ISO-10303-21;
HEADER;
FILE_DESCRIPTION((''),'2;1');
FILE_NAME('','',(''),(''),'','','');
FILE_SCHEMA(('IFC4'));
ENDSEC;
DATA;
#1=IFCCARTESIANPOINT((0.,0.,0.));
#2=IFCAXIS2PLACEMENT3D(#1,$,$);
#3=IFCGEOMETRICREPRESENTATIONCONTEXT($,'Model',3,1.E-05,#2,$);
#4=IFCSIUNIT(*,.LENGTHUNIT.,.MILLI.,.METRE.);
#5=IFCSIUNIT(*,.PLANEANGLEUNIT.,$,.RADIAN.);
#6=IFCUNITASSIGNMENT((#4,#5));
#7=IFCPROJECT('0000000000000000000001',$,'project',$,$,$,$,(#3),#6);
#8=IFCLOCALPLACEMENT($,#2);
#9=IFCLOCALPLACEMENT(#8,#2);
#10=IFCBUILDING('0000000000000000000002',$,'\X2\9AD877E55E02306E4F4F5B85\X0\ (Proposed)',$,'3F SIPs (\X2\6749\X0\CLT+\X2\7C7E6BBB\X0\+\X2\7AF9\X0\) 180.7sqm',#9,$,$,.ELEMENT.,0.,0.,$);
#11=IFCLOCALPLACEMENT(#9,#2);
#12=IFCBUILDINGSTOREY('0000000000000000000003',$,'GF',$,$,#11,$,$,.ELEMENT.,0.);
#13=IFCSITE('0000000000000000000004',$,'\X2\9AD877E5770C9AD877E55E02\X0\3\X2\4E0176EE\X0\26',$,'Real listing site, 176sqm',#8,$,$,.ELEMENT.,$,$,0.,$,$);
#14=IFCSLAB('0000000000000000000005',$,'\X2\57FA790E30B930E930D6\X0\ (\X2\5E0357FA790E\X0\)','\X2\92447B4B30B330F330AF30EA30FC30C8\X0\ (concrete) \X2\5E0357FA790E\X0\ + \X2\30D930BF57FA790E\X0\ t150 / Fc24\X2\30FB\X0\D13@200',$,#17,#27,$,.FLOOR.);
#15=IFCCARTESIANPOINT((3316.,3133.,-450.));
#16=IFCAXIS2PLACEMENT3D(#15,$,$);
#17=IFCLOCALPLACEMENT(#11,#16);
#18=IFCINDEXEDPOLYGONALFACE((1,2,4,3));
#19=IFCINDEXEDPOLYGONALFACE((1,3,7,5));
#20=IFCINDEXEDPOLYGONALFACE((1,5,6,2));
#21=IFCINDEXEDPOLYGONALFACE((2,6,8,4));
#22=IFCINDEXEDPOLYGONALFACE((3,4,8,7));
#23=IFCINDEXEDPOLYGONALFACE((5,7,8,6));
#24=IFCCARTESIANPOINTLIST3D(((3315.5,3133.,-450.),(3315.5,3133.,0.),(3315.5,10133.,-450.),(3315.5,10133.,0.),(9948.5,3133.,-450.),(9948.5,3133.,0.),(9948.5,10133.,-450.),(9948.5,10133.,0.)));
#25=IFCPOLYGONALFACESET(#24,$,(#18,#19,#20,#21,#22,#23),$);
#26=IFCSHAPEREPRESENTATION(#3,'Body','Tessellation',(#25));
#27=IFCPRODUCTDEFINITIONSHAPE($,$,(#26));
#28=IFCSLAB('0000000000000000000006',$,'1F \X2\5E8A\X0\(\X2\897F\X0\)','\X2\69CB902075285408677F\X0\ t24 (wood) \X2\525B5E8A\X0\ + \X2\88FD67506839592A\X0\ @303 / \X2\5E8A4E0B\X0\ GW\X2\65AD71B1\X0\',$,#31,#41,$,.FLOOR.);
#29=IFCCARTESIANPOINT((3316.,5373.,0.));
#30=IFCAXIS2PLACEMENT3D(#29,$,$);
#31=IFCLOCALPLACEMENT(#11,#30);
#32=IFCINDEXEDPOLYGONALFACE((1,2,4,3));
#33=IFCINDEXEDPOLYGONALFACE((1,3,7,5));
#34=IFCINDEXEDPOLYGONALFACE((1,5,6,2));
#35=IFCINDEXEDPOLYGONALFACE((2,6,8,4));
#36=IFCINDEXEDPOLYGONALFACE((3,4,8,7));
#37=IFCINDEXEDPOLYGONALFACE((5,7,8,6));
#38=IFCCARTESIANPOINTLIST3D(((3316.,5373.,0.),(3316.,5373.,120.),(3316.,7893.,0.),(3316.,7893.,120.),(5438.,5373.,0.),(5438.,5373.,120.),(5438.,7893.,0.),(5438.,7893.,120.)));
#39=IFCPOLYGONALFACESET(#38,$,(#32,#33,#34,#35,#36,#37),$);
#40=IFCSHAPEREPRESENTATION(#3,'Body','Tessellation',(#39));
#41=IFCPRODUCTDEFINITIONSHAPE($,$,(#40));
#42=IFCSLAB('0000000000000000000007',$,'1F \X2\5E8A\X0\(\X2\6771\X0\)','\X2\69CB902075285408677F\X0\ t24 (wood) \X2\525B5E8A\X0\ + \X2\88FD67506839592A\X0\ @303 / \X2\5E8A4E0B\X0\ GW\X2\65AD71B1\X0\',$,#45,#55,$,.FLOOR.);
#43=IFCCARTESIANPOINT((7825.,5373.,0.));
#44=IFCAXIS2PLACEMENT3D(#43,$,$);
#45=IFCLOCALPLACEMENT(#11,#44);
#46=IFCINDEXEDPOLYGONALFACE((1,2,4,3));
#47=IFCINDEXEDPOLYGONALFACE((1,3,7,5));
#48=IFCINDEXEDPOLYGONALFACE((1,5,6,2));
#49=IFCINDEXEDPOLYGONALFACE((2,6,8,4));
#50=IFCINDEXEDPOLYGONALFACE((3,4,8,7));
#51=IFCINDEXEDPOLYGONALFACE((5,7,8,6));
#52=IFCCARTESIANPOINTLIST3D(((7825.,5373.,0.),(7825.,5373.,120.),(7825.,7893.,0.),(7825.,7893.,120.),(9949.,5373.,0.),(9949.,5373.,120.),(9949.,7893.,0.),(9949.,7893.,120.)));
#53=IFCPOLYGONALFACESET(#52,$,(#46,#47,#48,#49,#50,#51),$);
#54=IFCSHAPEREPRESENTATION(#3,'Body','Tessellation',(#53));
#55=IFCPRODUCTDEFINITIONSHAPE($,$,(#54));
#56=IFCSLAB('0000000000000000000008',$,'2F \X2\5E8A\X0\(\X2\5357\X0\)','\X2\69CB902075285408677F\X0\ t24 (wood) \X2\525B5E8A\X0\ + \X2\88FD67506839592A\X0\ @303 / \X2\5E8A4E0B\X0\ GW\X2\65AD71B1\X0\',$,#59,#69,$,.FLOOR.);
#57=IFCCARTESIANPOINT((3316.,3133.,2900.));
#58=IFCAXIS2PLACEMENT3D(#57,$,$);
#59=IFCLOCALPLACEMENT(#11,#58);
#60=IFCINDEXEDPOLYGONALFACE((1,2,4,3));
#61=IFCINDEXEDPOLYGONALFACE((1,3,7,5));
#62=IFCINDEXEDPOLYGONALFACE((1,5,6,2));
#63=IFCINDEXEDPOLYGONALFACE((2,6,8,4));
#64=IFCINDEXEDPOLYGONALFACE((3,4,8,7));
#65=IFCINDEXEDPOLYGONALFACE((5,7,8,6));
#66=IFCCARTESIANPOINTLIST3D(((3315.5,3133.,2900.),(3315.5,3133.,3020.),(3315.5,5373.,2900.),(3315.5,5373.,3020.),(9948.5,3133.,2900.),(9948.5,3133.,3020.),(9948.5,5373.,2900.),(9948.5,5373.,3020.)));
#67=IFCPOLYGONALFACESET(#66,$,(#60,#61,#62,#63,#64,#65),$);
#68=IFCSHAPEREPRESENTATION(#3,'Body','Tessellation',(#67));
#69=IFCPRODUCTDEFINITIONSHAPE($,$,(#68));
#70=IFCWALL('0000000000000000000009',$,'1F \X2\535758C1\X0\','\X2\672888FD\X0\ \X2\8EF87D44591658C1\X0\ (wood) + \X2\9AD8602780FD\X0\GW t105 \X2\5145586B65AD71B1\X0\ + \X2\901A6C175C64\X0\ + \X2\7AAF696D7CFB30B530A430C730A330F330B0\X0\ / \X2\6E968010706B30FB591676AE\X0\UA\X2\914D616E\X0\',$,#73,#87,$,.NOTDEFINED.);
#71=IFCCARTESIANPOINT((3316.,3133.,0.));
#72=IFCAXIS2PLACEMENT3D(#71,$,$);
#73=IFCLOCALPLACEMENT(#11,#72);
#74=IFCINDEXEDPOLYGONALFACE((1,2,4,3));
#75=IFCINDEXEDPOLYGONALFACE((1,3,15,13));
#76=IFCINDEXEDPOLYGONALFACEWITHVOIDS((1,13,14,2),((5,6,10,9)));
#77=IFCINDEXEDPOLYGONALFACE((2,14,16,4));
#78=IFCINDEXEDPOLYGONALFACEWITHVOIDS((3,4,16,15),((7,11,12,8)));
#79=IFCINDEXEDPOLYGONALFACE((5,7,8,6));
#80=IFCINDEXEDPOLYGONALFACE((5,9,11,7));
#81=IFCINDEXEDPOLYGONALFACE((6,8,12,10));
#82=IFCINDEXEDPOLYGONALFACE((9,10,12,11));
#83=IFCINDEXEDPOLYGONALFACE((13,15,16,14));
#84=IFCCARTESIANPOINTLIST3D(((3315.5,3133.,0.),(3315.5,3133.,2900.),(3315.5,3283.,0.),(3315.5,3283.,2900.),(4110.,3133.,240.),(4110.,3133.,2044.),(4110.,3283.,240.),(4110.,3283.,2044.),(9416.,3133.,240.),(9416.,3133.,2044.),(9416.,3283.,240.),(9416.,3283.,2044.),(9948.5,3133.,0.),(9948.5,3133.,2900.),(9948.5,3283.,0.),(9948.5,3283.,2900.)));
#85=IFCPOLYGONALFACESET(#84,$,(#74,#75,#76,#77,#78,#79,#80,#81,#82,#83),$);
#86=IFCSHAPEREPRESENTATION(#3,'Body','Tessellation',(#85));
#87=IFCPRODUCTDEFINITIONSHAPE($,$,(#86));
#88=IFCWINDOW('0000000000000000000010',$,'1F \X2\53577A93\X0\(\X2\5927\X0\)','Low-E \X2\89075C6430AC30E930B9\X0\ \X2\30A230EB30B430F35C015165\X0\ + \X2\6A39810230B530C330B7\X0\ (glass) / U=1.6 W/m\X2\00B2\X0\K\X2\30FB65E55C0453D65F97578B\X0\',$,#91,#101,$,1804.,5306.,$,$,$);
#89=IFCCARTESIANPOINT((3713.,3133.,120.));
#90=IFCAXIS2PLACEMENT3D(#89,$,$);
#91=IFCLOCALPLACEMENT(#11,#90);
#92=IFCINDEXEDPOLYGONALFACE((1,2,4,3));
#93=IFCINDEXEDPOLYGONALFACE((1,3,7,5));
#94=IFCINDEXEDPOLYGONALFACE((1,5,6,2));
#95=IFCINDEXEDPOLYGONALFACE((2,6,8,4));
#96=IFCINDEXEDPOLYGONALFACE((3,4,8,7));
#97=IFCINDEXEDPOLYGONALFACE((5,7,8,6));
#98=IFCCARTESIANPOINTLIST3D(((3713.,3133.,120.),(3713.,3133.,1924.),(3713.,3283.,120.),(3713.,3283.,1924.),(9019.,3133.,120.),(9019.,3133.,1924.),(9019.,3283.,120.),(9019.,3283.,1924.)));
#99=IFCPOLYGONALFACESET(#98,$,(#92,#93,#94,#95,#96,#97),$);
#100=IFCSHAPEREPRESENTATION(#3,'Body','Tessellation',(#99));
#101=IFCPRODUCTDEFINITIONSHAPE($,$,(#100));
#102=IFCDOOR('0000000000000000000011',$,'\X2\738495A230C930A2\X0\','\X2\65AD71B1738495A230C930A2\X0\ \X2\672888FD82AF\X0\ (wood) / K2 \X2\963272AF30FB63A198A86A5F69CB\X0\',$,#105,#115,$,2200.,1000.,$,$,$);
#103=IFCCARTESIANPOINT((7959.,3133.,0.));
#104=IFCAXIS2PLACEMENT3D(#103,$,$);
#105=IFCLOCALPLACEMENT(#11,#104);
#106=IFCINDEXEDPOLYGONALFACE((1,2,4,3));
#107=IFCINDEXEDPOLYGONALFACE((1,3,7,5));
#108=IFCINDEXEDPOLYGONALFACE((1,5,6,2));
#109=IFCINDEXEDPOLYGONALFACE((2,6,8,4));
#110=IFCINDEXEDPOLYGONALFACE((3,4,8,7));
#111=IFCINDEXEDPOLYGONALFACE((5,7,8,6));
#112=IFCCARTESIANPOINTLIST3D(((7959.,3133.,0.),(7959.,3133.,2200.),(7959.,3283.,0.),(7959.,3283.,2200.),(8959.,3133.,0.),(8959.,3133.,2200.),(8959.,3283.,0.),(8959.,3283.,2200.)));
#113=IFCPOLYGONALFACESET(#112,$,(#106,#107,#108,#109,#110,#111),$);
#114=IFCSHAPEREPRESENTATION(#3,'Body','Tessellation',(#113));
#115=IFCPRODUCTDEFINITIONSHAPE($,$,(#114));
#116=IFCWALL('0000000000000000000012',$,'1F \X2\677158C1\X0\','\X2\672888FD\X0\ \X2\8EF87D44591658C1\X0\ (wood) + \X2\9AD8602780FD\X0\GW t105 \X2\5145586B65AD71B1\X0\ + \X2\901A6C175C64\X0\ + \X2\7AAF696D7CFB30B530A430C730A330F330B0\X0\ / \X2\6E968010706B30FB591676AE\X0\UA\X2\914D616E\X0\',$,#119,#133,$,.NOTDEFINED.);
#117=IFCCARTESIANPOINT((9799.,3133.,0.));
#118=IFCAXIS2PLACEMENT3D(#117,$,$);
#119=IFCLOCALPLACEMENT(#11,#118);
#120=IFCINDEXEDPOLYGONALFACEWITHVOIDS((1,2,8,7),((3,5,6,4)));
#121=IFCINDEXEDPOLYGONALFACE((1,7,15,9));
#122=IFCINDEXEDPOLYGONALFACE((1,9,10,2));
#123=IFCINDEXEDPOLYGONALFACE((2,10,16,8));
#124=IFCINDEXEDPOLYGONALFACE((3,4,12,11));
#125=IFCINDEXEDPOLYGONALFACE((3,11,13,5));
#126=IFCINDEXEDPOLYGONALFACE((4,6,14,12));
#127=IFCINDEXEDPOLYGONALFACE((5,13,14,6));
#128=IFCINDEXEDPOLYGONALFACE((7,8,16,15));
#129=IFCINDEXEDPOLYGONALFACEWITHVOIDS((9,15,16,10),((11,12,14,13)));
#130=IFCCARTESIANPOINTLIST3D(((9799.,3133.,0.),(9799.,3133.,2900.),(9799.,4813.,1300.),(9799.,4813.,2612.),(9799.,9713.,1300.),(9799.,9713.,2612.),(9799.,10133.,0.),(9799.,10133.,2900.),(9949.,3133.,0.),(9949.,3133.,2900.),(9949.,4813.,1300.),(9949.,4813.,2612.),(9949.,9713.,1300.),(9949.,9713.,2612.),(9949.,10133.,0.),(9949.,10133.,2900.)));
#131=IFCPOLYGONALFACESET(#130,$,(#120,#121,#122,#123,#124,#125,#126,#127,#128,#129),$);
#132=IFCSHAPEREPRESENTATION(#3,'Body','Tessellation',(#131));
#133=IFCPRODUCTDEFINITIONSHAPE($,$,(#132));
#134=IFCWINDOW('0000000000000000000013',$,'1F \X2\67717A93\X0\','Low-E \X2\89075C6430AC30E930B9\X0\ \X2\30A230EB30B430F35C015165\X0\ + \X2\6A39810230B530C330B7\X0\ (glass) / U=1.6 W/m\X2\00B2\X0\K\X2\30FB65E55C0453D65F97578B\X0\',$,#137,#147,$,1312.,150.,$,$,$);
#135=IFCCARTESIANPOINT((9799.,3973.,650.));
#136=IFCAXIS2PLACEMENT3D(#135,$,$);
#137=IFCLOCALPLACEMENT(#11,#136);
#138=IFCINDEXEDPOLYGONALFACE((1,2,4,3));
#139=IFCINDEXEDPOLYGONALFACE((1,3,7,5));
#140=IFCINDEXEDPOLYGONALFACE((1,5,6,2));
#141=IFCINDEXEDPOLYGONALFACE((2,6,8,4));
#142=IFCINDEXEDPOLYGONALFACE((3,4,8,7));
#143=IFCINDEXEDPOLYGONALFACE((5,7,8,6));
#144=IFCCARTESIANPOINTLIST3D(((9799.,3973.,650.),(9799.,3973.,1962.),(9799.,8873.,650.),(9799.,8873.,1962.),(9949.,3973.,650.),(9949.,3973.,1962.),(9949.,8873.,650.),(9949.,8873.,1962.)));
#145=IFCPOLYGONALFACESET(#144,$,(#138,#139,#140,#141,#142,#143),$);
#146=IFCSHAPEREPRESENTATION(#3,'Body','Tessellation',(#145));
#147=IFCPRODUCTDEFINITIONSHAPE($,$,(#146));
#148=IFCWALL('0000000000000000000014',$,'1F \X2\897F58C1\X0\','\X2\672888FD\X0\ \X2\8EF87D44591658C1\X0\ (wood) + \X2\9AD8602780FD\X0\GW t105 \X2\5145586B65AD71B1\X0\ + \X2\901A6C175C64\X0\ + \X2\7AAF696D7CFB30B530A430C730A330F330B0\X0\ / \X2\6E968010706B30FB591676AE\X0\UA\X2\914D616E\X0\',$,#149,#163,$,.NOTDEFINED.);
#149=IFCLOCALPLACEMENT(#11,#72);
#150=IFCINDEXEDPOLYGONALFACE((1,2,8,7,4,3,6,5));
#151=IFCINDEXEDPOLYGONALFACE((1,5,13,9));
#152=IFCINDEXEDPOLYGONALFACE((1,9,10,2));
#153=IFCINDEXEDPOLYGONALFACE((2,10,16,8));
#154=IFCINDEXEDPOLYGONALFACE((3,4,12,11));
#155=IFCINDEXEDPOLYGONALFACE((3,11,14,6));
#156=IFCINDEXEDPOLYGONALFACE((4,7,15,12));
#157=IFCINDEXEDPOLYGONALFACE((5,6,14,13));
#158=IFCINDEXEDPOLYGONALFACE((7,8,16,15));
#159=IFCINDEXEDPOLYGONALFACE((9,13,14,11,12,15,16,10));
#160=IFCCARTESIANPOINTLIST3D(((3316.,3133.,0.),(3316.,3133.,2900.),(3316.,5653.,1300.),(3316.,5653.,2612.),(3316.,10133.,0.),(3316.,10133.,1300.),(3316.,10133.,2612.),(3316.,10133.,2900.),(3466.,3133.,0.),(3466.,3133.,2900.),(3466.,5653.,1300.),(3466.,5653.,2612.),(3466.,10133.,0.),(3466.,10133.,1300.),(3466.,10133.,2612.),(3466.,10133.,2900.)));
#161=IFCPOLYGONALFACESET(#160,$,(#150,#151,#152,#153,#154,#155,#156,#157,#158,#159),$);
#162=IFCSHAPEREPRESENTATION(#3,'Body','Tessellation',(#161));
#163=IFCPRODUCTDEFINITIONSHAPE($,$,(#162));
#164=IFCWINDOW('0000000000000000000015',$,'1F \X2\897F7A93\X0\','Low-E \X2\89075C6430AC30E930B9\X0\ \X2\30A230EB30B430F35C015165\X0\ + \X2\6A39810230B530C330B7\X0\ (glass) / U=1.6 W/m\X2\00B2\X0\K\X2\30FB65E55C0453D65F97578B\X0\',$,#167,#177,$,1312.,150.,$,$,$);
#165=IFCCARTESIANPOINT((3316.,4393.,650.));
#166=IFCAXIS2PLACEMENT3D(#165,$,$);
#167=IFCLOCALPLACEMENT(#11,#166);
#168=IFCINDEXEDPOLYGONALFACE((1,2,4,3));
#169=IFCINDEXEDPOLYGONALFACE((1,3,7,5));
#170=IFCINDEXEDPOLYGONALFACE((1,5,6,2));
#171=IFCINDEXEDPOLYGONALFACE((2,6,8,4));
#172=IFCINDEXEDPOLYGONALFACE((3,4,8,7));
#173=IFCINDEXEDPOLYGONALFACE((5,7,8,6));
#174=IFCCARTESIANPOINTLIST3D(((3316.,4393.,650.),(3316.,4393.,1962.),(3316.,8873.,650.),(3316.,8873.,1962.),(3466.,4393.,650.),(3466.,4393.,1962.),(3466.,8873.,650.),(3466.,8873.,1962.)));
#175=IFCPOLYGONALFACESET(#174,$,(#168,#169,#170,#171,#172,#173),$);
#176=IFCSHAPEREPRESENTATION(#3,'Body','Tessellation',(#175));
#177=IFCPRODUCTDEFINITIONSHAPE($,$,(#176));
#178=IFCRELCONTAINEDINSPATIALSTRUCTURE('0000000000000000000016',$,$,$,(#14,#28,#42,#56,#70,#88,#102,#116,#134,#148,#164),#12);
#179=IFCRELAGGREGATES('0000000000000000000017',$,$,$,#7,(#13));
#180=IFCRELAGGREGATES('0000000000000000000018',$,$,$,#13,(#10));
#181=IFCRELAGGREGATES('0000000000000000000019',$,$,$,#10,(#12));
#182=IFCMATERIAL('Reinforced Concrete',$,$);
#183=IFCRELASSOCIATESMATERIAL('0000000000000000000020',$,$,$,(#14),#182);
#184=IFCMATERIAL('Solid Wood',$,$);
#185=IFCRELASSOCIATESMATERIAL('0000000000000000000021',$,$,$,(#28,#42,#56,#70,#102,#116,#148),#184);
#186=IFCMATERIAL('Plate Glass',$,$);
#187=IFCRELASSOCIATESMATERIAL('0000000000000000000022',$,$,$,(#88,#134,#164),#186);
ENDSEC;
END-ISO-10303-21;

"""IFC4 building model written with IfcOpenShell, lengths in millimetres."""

from ifc_helpers import new_model, si_unit, frame, frame_2d, origin, place, context, project, spatial, rectangle, extrude, material, element, fill, save


model = new_model("IFC4")

# Units and contexts
model_context = context("Model", 3, precision=1e-05, world=origin())
ifc_project = project(units=[si_unit("LENGTHUNIT", "METRE", prefix="MILLI"), si_unit("PLANEANGLEUNIT", "RADIAN")], contexts=[model_context])

# Site, building, storey
site_placement = place(None, origin())
site = spatial("IfcSite", under=ifc_project, at=site_placement, Name="高知県高知市3丁目26", ObjectType="Real listing site, 176sqm", CompositionType="ELEMENT", RefElevation=0.0)
building_placement = place(site_placement, origin())
building = spatial("IfcBuilding", under=site, at=building_placement, Name="高知市の住宅 (Proposed)", ObjectType="3F SIPs (杉CLT+籾殻+竹) 180.7sqm", CompositionType="ELEMENT", ElevationOfRefHeight=0.0, ElevationOfTerrain=0.0)
storey_placement = place(building_placement, origin())
storey = spatial("IfcBuildingStorey", under=building, at=storey_placement, Name="GF", CompositionType="ELEMENT", Elevation=0.0)

# Slabs
ifc_material_1 = material(Name="Reinforced Concrete")
slab_1_placement = place(storey_placement, frame((3316.0, 3133.0, -450.0)))
element("IfcSlab", 1, at=slab_1_placement, inside=storey, material=ifc_material_1, Name="基礎スラブ (布基礎)", Description="鉄筋コンクリート (concrete) 布基礎 + ベタ基礎 t150 / Fc24・D13@200", PredefinedType="FLOOR", context=model_context, shape_type="SweptSolid", body=[
    extrude(rectangle(XDim=6633.0, YDim=7000.0, at=frame_2d((3316.0, 3500.0))), frame((3316.0, 3133.0, -450.0)), (0.0, 0.0, 1.0), 450.0),
])
ifc_material_2 = material(Name="Solid Wood")
slab_2_placement = place(storey_placement, frame((3316.0, 5373.0, 0.0)))
element("IfcSlab", 2, at=slab_2_placement, inside=storey, material=ifc_material_2, Name="1F 床(西)", Description="構造用合板 t24 (wood) 剛床 + 製材根太 @303 / 床下 GW断熱", PredefinedType="FLOOR", context=model_context, shape_type="SweptSolid", body=[
    extrude(rectangle(XDim=2122.0, YDim=2520.0, at=frame_2d((1061.0, 1260.0))), frame((3316.0, 5373.0, 0.0)), (0.0, 0.0, 1.0), 120.0),
])
slab_3_placement = place(storey_placement, frame((7825.0, 5373.0, 0.0)))
element("IfcSlab", 3, at=slab_3_placement, inside=storey, material=ifc_material_2, Name="1F 床(東)", Description="構造用合板 t24 (wood) 剛床 + 製材根太 @303 / 床下 GW断熱", PredefinedType="FLOOR", context=model_context, shape_type="SweptSolid", body=[
    extrude(rectangle(XDim=2124.0, YDim=2520.0, at=frame_2d((1062.0, 1260.0))), frame((7825.0, 5373.0, 0.0)), (0.0, 0.0, 1.0), 120.0),
])
slab_4_placement = place(storey_placement, frame((3316.0, 3133.0, 2900.0)))
element("IfcSlab", 4, at=slab_4_placement, inside=storey, material=ifc_material_2, Name="2F 床(南)", Description="構造用合板 t24 (wood) 剛床 + 製材根太 @303 / 床下 GW断熱", PredefinedType="FLOOR", context=model_context, shape_type="SweptSolid", body=[
    extrude(rectangle(XDim=6633.0, YDim=2240.0, at=frame_2d((3316.0, 1120.0))), frame((3316.0, 3133.0, 2900.0)), (0.0, 0.0, 1.0), 120.0),
])

# Wall, openings, window, door
wall_1_placement = place(storey_placement, frame((3316.0, 3133.0, 0.0)))
wall_1 = element("IfcWall", 5, at=wall_1_placement, inside=storey, material=ifc_material_2, Name="1F 南壁", Description="木製 軸組外壁 (wood) + 高性能GW t105 充填断熱 + 通気層 + 窯業系サイディング / 準耐火・外皮UA配慮", PredefinedType="NOTDEFINED", context=model_context, shape_type="SweptSolid", body=[
    extrude(rectangle(XDim=6633.0, YDim=150.0, at=frame_2d((3316.0, 75.0))), frame((3316.0, 3133.0, 0.0)), (0.0, 0.0, 1.0), 2900.0),
])
opening_1_placement = place(storey_placement, frame((3713.0, 3133.0, 120.0)))
opening_1 = element("IfcOpeningElement", 6, at=opening_1_placement, cuts=wall_1, PredefinedType="NOTDEFINED", context=model_context, shape_type="SweptSolid", body=[
    extrude(rectangle(XDim=5306.0, YDim=150.0, at=frame_2d((2653.0, 75.0))), frame((3713.0, 3133.0, 120.0)), (0.0, 0.0, 1.0), 1804.0),
])
opening_2_placement = place(storey_placement, frame((7959.0, 3133.0, 0.0)))
opening_2 = element("IfcOpeningElement", 7, at=opening_2_placement, cuts=wall_1, PredefinedType="NOTDEFINED", context=model_context, shape_type="SweptSolid", body=[
    extrude(rectangle(XDim=1000.0, YDim=150.0, at=frame_2d((500.0, 75.0))), frame((7959.0, 3133.0, 0.0)), (0.0, 0.0, 1.0), 2200.0),
])
ifc_material_3 = material(Name="Plate Glass")
window_1_placement = place(storey_placement, frame((3713.0, 3133.0, 120.0)))
window_1 = element("IfcWindow", 8, at=window_1_placement, inside=storey, material=ifc_material_3, Name="1F 南窓(大)", Description="Low-E 複層ガラス アルゴン封入 + 樹脂サッシ (glass) / U=1.6 W/m²K・日射取得型", OverallHeight=1804.0, OverallWidth=5306.0, context=model_context, shape_type="SweptSolid", body=[
    extrude(rectangle(XDim=5306.0, YDim=150.0, at=frame_2d((2653.0, 75.0))), frame((3713.0, 3133.0, 120.0)), (0.0, 0.0, 1.0), 1804.0),
])
fill(opening_1, window_1)
door_placement = place(storey_placement, frame((7959.0, 3133.0, 0.0)))
door = element("IfcDoor", 9, at=door_placement, inside=storey, material=ifc_material_2, Name="玄関ドア", Description="断熱玄関ドア 木製芯 (wood) / K2 防犯・採風機構", OverallHeight=2200.0, OverallWidth=1000.0, context=model_context, shape_type="SweptSolid", body=[
    extrude(rectangle(XDim=1000.0, YDim=150.0, at=frame_2d((500.0, 75.0))), frame((7959.0, 3133.0, 0.0)), (0.0, 0.0, 1.0), 2200.0),
])
fill(opening_2, door)

# Walls, openings, windows
wall_2_placement = place(storey_placement, frame((9799.0, 3133.0, 0.0)))
wall_2 = element("IfcWall", 10, at=wall_2_placement, inside=storey, material=ifc_material_2, Name="1F 東壁", Description="木製 軸組外壁 (wood) + 高性能GW t105 充填断熱 + 通気層 + 窯業系サイディング / 準耐火・外皮UA配慮", PredefinedType="NOTDEFINED", context=model_context, shape_type="SweptSolid", body=[
    extrude(rectangle(XDim=150.0, YDim=7000.0, at=frame_2d((75.0, 3500.0))), frame((9799.0, 3133.0, 0.0)), (0.0, 0.0, 1.0), 2900.0),
])
opening_3_placement = place(storey_placement, frame((9799.0, 3973.0, 650.0)))
opening_3 = element("IfcOpeningElement", 11, at=opening_3_placement, cuts=wall_2, PredefinedType="NOTDEFINED", context=model_context, shape_type="SweptSolid", body=[
    extrude(rectangle(XDim=150.0, YDim=4900.0, at=frame_2d((75.0, 2450.0))), frame((9799.0, 3973.0, 650.0)), (0.0, 0.0, 1.0), 1312.0),
])
window_2_placement = place(storey_placement, frame((9799.0, 3973.0, 650.0)))
window_2 = element("IfcWindow", 12, at=window_2_placement, inside=storey, material=ifc_material_3, Name="1F 東窓", Description="Low-E 複層ガラス アルゴン封入 + 樹脂サッシ (glass) / U=1.6 W/m²K・日射取得型", OverallHeight=1312.0, OverallWidth=150.0, context=model_context, shape_type="SweptSolid", body=[
    extrude(rectangle(XDim=150.0, YDim=4900.0, at=frame_2d((75.0, 2450.0))), frame((9799.0, 3973.0, 650.0)), (0.0, 0.0, 1.0), 1312.0),
])
fill(opening_3, window_2)
wall_3_placement = place(storey_placement, frame((3316.0, 3133.0, 0.0)))
wall_3 = element("IfcWall", 13, at=wall_3_placement, inside=storey, material=ifc_material_2, Name="1F 西壁", Description="木製 軸組外壁 (wood) + 高性能GW t105 充填断熱 + 通気層 + 窯業系サイディング / 準耐火・外皮UA配慮", PredefinedType="NOTDEFINED", context=model_context, shape_type="SweptSolid", body=[
    extrude(rectangle(XDim=150.0, YDim=7000.0, at=frame_2d((75.0, 3500.0))), frame((3316.0, 3133.0, 0.0)), (0.0, 0.0, 1.0), 2900.0),
])
opening_4_placement = place(storey_placement, frame((3316.0, 4393.0, 650.0)))
opening_4 = element("IfcOpeningElement", 14, at=opening_4_placement, cuts=wall_3, PredefinedType="NOTDEFINED", context=model_context, shape_type="SweptSolid", body=[
    extrude(rectangle(XDim=150.0, YDim=4480.0, at=frame_2d((75.0, 2240.0))), frame((3316.0, 4393.0, 650.0)), (0.0, 0.0, 1.0), 1312.0),
])
window_3_placement = place(storey_placement, frame((3316.0, 4393.0, 650.0)))
window_3 = element("IfcWindow", 15, at=window_3_placement, inside=storey, material=ifc_material_3, Name="1F 西窓", Description="Low-E 複層ガラス アルゴン封入 + 樹脂サッシ (glass) / U=1.6 W/m²K・日射取得型", OverallHeight=1312.0, OverallWidth=150.0, context=model_context, shape_type="SweptSolid", body=[
    extrude(rectangle(XDim=150.0, YDim=4480.0, at=frame_2d((75.0, 2240.0))), frame((3316.0, 4393.0, 650.0)), (0.0, 0.0, 1.0), 1312.0),
])
fill(opening_4, window_3)

save(model, "model.ifc")
